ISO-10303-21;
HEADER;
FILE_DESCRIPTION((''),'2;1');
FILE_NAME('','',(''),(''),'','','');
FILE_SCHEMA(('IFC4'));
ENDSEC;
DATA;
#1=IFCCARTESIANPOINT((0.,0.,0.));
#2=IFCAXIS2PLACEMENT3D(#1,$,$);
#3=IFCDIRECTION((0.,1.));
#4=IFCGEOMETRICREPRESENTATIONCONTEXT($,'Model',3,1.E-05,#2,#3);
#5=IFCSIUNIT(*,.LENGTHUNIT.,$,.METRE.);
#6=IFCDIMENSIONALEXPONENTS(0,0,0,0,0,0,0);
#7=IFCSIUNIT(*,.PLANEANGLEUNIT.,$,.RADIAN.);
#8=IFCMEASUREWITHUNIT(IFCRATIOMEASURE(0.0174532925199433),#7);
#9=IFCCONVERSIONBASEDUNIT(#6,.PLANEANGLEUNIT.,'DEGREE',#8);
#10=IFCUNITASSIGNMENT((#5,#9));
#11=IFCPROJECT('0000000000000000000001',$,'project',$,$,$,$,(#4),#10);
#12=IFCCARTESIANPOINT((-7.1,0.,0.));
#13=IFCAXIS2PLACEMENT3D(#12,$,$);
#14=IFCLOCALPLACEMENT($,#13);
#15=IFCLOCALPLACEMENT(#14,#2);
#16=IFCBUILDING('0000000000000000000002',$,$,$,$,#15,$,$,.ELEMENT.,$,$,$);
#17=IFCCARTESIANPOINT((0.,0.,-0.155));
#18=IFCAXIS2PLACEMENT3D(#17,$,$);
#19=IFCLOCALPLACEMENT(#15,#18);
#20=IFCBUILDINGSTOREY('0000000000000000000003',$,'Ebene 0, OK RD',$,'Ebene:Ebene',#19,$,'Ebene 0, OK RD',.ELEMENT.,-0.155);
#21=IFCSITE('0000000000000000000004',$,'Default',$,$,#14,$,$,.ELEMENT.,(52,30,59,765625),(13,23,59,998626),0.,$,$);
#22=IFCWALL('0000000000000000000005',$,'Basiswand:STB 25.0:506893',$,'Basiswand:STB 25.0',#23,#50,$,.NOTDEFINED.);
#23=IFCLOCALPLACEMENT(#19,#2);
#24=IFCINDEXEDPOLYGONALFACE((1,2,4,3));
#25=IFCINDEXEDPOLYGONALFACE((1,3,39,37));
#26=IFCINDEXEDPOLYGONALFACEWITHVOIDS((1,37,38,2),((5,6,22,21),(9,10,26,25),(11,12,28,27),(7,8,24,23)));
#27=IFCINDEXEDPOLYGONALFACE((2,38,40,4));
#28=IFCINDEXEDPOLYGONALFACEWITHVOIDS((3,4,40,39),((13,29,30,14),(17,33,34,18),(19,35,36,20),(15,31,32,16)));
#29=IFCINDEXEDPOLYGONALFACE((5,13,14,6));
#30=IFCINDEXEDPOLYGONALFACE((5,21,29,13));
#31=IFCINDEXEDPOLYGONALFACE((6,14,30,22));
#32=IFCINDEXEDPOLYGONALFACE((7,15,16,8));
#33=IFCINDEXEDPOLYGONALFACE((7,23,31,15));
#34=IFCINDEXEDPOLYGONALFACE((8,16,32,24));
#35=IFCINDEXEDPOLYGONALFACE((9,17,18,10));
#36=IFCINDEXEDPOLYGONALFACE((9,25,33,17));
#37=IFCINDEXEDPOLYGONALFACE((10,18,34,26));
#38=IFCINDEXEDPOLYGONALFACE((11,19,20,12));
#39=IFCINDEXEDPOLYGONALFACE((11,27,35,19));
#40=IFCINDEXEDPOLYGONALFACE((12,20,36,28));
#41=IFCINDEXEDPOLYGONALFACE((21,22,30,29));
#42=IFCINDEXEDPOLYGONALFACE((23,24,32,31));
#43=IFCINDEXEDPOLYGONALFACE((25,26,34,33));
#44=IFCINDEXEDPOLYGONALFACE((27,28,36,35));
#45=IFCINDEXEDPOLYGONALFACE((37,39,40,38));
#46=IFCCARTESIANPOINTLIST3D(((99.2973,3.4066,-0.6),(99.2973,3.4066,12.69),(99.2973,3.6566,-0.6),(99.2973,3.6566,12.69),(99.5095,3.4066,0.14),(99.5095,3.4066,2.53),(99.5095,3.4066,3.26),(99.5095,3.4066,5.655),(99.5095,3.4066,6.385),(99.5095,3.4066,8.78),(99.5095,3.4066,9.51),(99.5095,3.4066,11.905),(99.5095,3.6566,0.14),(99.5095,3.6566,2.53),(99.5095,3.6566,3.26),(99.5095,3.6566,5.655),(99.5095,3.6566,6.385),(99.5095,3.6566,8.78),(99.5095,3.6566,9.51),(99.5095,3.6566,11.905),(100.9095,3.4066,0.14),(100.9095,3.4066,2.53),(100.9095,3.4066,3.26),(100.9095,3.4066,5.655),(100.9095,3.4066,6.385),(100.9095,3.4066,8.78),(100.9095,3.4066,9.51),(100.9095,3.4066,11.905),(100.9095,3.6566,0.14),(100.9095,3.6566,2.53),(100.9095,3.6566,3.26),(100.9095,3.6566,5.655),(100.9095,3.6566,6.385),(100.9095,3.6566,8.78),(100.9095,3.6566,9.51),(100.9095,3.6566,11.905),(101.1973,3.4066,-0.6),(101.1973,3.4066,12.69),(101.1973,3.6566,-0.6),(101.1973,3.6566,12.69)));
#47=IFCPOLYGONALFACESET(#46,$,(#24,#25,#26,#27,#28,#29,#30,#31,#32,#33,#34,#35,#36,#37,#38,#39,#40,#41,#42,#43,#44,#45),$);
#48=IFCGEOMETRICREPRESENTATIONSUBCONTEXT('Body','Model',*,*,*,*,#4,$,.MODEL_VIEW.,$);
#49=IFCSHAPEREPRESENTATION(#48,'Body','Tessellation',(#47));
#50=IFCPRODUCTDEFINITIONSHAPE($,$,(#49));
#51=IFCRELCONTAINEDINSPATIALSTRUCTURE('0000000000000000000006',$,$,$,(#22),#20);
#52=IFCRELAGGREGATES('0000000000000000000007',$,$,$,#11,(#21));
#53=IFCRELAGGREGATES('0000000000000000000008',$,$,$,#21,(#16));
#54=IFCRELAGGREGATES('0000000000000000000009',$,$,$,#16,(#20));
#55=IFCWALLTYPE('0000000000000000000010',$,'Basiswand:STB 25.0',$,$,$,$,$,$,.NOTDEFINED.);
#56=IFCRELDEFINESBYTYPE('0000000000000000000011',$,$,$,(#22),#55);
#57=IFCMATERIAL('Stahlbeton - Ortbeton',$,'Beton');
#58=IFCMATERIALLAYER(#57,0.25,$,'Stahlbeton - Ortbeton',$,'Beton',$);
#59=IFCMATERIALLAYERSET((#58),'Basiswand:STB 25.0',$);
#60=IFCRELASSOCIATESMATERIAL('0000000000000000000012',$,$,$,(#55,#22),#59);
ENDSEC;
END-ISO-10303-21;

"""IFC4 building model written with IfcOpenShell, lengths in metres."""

from ifc_helpers import new_model, entity, si_unit, converted_unit, direction, frame, frame_2d, origin, origin_2d_with_axis, place, context, subcontext, project, spatial, rectangle, extrude, material, layer, layer_set, layer_usage, type_object, element, save


model = new_model("IFC4")

# Units and contexts
model_context = context("Model", 3, precision=1e-05, world=origin(), true_north=direction((0.0, 1.0)))
body_context = subcontext(model_context, "Body", "Model", "MODEL_VIEW")
ifc_project = project(units=[si_unit("LENGTHUNIT", "METRE"), converted_unit("PLANEANGLEUNIT", "DEGREE", entity("IfcRatioMeasure", 0.0174532925199433), si_unit("PLANEANGLEUNIT", "RADIAN"), dimensions=[0, 0, 0, 0, 0, 0, 0])], contexts=[model_context])

# Site, building, storey
site_placement = place(None, frame((-7.1, 0.0, 0.0)))
site = spatial("IfcSite", under=ifc_project, at=site_placement, Name="Default", CompositionType="ELEMENT", RefLatitude=(52, 30, 59, 765625), RefLongitude=(13, 23, 59, 998626), RefElevation=0.0)
building_placement = place(site_placement, origin())
building = spatial("IfcBuilding", under=site, at=building_placement, CompositionType="ELEMENT")
storey_placement = place(building_placement, frame((0.0, 0.0, -0.155)))
storey = spatial("IfcBuildingStorey", under=building, at=storey_placement, Name="Ebene 0, OK RD", ObjectType="Ebene:Ebene", LongName="Ebene 0, OK RD", CompositionType="ELEMENT", Elevation=-0.155)

# Shared definitions
ifc_material_1 = material(Name="Stahlbeton - Ortbeton", Category="Beton")
ifc_layer_1 = layer(ifc_material_1, 0.25, Name="Stahlbeton - Ortbeton", Category="Beton")
ifc_layer_set_1 = layer_set([ifc_layer_1], Name="Basiswand:STB 25.0")
wall_type_1 = type_object("IfcWallType", Name="Basiswand:STB 25.0", PredefinedType="NOTDEFINED", material=ifc_layer_set_1)

# Wall, openings
ifc_layer_usage_1 = layer_usage(ifc_layer_set_1, "AXIS2", "POSITIVE", -0.125)
wall_1_placement = place(storey_placement, frame((99.2973, 3.5316, -0.6)))
wall_1 = element("IfcWall", 1, at=wall_1_placement, inside=storey, type_object=wall_type_1, material=ifc_layer_usage_1, Name="Basiswand:STB 25.0:506893", ObjectType="Basiswand:STB 25.0", PredefinedType="NOTDEFINED", context=body_context, shape_type="SweptSolid", body=[
    extrude(rectangle(XDim=1.9, YDim=0.25, at=frame_2d((0.95, 0.0), x_axis=(-1.0, 0.0))), origin(), (0.0, 0.0, 1.0), 13.29),
])
opening_1_placement = place(wall_1_placement, frame((0.2122, -0.125, 0.74)))
element("IfcOpeningElement", 2, at=opening_1_placement, cuts=wall_1, ObjectType="Opening", PredefinedType="OPENING", context=body_context, shape_type="SweptSolid", body=[
    extrude(rectangle(XDim=2.39, YDim=1.4, at=origin_2d_with_axis()), frame((0.7, 0.0, 1.195), z_axis=(0.0, 1.0, 0.0), x_axis=(0.0, 0.0, -1.0)), (0.0, 0.0, 1.0), 0.25),
])
opening_2_placement = place(wall_1_placement, frame((0.2122, -0.125, 3.86)))
element("IfcOpeningElement", 3, at=opening_2_placement, cuts=wall_1, ObjectType="Opening", PredefinedType="OPENING", context=body_context, shape_type="SweptSolid", body=[
    extrude(rectangle(XDim=2.395, YDim=1.4, at=origin_2d_with_axis()), frame((0.7, 0.0, 1.1975), z_axis=(0.0, 1.0, 0.0), x_axis=(0.0, 0.0, -1.0)), (0.0, 0.0, 1.0), 0.25),
])
opening_3_placement = place(wall_1_placement, frame((0.2122, -0.125, 6.985)))
element("IfcOpeningElement", 4, at=opening_3_placement, cuts=wall_1, ObjectType="Opening", PredefinedType="OPENING", context=body_context, shape_type="SweptSolid", body=[
    extrude(rectangle(XDim=2.395, YDim=1.4, at=frame_2d((0.0, 0.0), x_axis=(1.0, 0.0))), frame((0.7, 0.0, 1.1975), z_axis=(0.0, 1.0, 0.0), x_axis=(0.0, 0.0, -1.0)), (0.0, 0.0, 1.0), 0.25),
])
opening_4_placement = place(wall_1_placement, frame((0.2122, -0.125, 10.11)))
element("IfcOpeningElement", 5, at=opening_4_placement, cuts=wall_1, ObjectType="Opening", PredefinedType="OPENING", context=body_context, shape_type="SweptSolid", body=[
    extrude(rectangle(XDim=2.395, YDim=1.4, at=frame_2d((0.0, 0.0), x_axis=(1.0, 0.0))), frame((0.7, 0.0, 1.1975), z_axis=(0.0, 1.0, 0.0), x_axis=(0.0, 0.0, -1.0)), (0.0, 0.0, 1.0), 0.25),
])

save(model, "model.ifc")
